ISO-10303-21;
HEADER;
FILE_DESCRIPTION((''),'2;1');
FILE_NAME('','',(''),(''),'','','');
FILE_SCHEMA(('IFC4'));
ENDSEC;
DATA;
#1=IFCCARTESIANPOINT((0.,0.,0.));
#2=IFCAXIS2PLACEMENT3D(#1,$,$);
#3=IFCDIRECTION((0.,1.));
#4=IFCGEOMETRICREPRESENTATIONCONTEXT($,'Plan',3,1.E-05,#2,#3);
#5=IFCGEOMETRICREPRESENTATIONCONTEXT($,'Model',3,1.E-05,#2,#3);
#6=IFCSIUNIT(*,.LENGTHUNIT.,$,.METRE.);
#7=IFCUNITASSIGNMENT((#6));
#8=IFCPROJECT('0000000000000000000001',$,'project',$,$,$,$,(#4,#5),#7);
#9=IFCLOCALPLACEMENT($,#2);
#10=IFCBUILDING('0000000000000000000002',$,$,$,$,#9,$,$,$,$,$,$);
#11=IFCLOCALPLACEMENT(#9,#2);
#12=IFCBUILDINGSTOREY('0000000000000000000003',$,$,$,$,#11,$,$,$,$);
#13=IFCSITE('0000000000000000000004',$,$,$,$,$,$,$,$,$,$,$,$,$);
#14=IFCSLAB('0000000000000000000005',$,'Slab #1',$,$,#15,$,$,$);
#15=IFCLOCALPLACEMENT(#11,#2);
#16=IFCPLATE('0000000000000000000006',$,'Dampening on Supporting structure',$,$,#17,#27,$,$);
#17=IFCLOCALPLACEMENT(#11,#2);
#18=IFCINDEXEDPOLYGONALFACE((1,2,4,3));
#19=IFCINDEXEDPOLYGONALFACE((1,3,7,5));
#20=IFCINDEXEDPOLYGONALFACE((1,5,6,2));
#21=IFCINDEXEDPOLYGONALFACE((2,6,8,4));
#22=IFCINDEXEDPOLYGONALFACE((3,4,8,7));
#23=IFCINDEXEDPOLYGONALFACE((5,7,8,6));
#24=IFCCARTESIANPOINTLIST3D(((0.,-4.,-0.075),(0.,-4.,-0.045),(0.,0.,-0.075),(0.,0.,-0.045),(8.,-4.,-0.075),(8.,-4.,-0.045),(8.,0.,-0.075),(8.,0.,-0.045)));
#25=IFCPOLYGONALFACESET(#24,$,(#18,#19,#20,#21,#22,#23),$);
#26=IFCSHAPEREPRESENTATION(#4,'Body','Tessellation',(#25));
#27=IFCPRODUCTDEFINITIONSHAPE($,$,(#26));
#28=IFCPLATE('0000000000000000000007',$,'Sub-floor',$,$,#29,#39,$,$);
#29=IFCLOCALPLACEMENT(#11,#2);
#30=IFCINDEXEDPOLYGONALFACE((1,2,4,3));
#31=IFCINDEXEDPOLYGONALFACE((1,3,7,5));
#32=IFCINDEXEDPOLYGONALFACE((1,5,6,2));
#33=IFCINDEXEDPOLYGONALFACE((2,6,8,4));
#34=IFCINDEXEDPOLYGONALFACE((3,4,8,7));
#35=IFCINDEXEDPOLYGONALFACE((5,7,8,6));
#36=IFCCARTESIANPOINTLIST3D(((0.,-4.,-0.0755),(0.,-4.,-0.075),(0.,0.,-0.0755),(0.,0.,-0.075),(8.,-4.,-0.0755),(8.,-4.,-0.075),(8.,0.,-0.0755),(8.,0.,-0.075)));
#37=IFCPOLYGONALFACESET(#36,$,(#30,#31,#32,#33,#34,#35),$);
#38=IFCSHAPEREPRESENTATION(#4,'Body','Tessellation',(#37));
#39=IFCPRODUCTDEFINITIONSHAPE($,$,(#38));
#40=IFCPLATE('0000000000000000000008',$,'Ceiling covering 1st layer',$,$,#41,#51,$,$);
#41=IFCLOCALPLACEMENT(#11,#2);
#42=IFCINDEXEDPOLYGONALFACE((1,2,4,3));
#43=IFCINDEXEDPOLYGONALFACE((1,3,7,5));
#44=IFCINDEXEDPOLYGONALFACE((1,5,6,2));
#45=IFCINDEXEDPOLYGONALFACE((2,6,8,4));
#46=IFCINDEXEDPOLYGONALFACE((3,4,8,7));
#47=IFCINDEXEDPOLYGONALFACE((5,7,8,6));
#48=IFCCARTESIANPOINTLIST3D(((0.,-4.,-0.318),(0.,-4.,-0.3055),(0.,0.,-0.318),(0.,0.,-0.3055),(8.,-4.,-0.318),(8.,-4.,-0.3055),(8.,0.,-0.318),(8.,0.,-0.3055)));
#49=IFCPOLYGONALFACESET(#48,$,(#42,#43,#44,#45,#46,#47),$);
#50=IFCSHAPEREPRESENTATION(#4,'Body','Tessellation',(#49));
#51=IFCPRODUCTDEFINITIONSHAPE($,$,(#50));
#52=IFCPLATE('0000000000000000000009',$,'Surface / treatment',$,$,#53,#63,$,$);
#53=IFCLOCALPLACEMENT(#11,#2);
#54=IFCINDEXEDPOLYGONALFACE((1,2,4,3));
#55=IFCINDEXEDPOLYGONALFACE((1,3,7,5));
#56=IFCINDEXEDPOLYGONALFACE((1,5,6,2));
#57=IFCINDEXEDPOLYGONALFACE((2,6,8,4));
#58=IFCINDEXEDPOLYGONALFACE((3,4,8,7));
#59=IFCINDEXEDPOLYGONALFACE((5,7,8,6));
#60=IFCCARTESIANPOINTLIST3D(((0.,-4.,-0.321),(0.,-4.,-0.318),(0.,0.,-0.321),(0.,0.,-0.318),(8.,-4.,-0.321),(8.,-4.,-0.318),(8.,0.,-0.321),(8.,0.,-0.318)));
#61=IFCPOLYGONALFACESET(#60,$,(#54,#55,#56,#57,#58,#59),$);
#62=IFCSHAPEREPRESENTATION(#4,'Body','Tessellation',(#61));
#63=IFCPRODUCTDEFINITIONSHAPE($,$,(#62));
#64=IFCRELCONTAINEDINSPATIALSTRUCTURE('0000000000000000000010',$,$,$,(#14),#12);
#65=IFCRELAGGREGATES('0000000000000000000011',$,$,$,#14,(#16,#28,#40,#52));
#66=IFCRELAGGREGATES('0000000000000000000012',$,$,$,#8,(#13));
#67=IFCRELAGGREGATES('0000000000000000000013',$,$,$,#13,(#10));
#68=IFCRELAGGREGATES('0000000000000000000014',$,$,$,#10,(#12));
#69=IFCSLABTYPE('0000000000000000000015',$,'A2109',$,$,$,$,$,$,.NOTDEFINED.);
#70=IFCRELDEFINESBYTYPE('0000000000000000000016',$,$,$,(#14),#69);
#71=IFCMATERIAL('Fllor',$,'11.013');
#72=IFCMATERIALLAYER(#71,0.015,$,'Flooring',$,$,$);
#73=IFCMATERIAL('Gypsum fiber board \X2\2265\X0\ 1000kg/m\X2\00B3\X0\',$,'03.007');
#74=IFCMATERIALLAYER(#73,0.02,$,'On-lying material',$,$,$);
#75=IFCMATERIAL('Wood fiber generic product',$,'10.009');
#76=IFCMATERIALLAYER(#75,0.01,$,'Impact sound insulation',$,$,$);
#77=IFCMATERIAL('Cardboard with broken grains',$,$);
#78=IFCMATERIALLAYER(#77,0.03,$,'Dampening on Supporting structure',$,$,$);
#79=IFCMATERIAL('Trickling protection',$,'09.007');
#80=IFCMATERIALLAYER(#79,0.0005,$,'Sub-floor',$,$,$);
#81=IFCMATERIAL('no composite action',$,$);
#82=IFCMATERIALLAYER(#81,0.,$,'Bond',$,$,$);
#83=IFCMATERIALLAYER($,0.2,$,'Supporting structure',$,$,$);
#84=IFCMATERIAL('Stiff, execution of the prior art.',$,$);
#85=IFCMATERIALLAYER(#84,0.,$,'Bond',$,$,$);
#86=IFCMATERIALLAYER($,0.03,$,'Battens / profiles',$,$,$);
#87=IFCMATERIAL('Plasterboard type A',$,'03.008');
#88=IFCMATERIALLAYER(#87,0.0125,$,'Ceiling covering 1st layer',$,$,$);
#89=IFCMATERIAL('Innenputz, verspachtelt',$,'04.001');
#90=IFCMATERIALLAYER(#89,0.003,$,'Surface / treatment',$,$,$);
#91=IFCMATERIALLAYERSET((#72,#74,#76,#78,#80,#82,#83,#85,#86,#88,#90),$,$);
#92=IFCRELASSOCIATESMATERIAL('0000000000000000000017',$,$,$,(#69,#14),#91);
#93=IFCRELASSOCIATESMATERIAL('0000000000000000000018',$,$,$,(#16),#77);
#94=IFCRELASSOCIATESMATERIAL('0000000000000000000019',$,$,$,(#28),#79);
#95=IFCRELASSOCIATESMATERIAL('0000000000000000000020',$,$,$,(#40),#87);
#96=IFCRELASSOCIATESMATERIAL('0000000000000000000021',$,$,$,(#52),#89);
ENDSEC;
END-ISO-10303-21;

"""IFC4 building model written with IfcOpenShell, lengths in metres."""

from ifc_helpers import new_model, si_unit, direction, frame, frame_2d, origin, place, context, project, spatial, rectangle, extrude, material, layer, layer_set, type_object, element, aggregate, save


model = new_model("IFC4")

# Units and contexts
plan_context = context("Plan", 3, precision=1e-05, world=origin(), true_north=direction((0.0, 1.0)))
model_context = context("Model", 3, precision=1e-05, world=origin(), true_north=direction((0.0, 1.0)))
ifc_project = project(units=[si_unit("LENGTHUNIT", "METRE")], contexts=[plan_context, model_context])

# Site, building, storey
site = spatial("IfcSite", under=ifc_project)
building_placement = place(None, origin())
building = spatial("IfcBuilding", under=site, at=building_placement)
storey_placement = place(building_placement, origin())
storey = spatial("IfcBuildingStorey", under=building, at=storey_placement)

# Slab, plates
ifc_material_1 = material(Name="Fllor", Category="11.013")
ifc_layer_1 = layer(ifc_material_1, 0.015, Name="Flooring")
ifc_material_2 = material(Name="Gypsum fiber board ≥ 1000kg/m³", Category="03.007")
ifc_layer_2 = layer(ifc_material_2, 0.02, Name="On-lying material")
ifc_material_3 = material(Name="Wood fiber generic product", Category="10.009")
ifc_layer_3 = layer(ifc_material_3, 0.01, Name="Impact sound insulation")
ifc_material_4 = material(Name="Cardboard with broken grains")
ifc_layer_4 = layer(ifc_material_4, 0.03, Name="Dampening on Supporting structure")
ifc_material_5 = material(Name="Trickling protection", Category="09.007")
ifc_layer_5 = layer(ifc_material_5, 0.0005, Name="Sub-floor")
ifc_material_6 = material(Name="no composite action")
ifc_layer_6 = layer(ifc_material_6, 0.0, Name="Bond")
ifc_layer_7 = layer(None, 0.2, Name="Supporting structure")
ifc_material_7 = material(Name="Stiff, execution of the prior art.")
ifc_layer_8 = layer(ifc_material_7, 0.0, Name="Bond")
ifc_layer_9 = layer(None, 0.03, Name="Battens / profiles")
ifc_material_8 = material(Name="Plasterboard type A", Category="03.008")
ifc_layer_10 = layer(ifc_material_8, 0.0125, Name="Ceiling covering 1st layer")
ifc_material_9 = material(Name="Innenputz, verspachtelt", Category="04.001")
ifc_layer_11 = layer(ifc_material_9, 0.003, Name="Surface / treatment")
ifc_layer_set = layer_set([ifc_layer_1, ifc_layer_2, ifc_layer_3, ifc_layer_4, ifc_layer_5, ifc_layer_6, ifc_layer_7, ifc_layer_8, ifc_layer_9, ifc_layer_10, ifc_layer_11])
slab_type = type_object("IfcSlabType", Name="A2109", PredefinedType="NOTDEFINED", material=ifc_layer_set)
slab_placement = place(None, frame((0.0, 0.0, 0.0), z_axis=(0.0, 0.0, -1.0), x_axis=(1.0, 0.0, 0.0)))
slab = element("IfcSlab", 1, at=slab_placement, inside=storey, type_object=slab_type, material=ifc_layer_set, Name="Slab #1")
plate_1_placement = place(slab_placement, origin())
plate_1 = element("IfcPlate", 2, at=plate_1_placement, material=ifc_material_4, Name="Dampening on Supporting structure", context=plan_context, shape_type="SweptSolid", body=[
    extrude(rectangle(XDim=8.0, YDim=4.0, at=frame_2d((4.0, 2.0), x_axis=(1.0, 0.0))), frame((0.0, 0.0, 0.045), z_axis=(0.0, 0.0, 1.0), x_axis=(1.0, 0.0, 0.0)), (0.0, 0.0, 1.0), 0.03),
])
plate_2_placement = place(slab_placement, origin())
plate_2 = element("IfcPlate", 3, at=plate_2_placement, material=ifc_material_5, Name="Sub-floor", context=plan_context, shape_type="SweptSolid", body=[
    extrude(rectangle(XDim=8.0, YDim=4.0, at=frame_2d((4.0, 2.0), x_axis=(1.0, 0.0))), frame((0.0, 0.0, 0.075), z_axis=(0.0, 0.0, 1.0), x_axis=(1.0, 0.0, 0.0)), (0.0, 0.0, 1.0), 0.0005),
])
plate_3_placement = place(slab_placement, origin())
plate_3 = element("IfcPlate", 4, at=plate_3_placement, material=ifc_material_8, Name="Ceiling covering 1st layer", context=plan_context, shape_type="SweptSolid", body=[
    extrude(rectangle(XDim=8.0, YDim=4.0, at=frame_2d((4.0, 2.0), x_axis=(1.0, 0.0))), frame((0.0, 0.0, 0.3055), z_axis=(0.0, 0.0, 1.0), x_axis=(1.0, 0.0, 0.0)), (0.0, 0.0, 1.0), 0.0125),
])
plate_4_placement = place(slab_placement, origin())
plate_4 = element("IfcPlate", 5, at=plate_4_placement, material=ifc_material_9, Name="Surface / treatment", context=plan_context, shape_type="SweptSolid", body=[
    extrude(rectangle(XDim=8.0, YDim=4.0, at=frame_2d((4.0, 2.0), x_axis=(1.0, 0.0))), frame((0.0, 0.0, 0.318), z_axis=(0.0, 0.0, 1.0), x_axis=(1.0, 0.0, 0.0)), (0.0, 0.0, 1.0), 0.003),
])
aggregate(slab, [plate_1, plate_2, plate_3, plate_4])

save(model, "model.ifc")
